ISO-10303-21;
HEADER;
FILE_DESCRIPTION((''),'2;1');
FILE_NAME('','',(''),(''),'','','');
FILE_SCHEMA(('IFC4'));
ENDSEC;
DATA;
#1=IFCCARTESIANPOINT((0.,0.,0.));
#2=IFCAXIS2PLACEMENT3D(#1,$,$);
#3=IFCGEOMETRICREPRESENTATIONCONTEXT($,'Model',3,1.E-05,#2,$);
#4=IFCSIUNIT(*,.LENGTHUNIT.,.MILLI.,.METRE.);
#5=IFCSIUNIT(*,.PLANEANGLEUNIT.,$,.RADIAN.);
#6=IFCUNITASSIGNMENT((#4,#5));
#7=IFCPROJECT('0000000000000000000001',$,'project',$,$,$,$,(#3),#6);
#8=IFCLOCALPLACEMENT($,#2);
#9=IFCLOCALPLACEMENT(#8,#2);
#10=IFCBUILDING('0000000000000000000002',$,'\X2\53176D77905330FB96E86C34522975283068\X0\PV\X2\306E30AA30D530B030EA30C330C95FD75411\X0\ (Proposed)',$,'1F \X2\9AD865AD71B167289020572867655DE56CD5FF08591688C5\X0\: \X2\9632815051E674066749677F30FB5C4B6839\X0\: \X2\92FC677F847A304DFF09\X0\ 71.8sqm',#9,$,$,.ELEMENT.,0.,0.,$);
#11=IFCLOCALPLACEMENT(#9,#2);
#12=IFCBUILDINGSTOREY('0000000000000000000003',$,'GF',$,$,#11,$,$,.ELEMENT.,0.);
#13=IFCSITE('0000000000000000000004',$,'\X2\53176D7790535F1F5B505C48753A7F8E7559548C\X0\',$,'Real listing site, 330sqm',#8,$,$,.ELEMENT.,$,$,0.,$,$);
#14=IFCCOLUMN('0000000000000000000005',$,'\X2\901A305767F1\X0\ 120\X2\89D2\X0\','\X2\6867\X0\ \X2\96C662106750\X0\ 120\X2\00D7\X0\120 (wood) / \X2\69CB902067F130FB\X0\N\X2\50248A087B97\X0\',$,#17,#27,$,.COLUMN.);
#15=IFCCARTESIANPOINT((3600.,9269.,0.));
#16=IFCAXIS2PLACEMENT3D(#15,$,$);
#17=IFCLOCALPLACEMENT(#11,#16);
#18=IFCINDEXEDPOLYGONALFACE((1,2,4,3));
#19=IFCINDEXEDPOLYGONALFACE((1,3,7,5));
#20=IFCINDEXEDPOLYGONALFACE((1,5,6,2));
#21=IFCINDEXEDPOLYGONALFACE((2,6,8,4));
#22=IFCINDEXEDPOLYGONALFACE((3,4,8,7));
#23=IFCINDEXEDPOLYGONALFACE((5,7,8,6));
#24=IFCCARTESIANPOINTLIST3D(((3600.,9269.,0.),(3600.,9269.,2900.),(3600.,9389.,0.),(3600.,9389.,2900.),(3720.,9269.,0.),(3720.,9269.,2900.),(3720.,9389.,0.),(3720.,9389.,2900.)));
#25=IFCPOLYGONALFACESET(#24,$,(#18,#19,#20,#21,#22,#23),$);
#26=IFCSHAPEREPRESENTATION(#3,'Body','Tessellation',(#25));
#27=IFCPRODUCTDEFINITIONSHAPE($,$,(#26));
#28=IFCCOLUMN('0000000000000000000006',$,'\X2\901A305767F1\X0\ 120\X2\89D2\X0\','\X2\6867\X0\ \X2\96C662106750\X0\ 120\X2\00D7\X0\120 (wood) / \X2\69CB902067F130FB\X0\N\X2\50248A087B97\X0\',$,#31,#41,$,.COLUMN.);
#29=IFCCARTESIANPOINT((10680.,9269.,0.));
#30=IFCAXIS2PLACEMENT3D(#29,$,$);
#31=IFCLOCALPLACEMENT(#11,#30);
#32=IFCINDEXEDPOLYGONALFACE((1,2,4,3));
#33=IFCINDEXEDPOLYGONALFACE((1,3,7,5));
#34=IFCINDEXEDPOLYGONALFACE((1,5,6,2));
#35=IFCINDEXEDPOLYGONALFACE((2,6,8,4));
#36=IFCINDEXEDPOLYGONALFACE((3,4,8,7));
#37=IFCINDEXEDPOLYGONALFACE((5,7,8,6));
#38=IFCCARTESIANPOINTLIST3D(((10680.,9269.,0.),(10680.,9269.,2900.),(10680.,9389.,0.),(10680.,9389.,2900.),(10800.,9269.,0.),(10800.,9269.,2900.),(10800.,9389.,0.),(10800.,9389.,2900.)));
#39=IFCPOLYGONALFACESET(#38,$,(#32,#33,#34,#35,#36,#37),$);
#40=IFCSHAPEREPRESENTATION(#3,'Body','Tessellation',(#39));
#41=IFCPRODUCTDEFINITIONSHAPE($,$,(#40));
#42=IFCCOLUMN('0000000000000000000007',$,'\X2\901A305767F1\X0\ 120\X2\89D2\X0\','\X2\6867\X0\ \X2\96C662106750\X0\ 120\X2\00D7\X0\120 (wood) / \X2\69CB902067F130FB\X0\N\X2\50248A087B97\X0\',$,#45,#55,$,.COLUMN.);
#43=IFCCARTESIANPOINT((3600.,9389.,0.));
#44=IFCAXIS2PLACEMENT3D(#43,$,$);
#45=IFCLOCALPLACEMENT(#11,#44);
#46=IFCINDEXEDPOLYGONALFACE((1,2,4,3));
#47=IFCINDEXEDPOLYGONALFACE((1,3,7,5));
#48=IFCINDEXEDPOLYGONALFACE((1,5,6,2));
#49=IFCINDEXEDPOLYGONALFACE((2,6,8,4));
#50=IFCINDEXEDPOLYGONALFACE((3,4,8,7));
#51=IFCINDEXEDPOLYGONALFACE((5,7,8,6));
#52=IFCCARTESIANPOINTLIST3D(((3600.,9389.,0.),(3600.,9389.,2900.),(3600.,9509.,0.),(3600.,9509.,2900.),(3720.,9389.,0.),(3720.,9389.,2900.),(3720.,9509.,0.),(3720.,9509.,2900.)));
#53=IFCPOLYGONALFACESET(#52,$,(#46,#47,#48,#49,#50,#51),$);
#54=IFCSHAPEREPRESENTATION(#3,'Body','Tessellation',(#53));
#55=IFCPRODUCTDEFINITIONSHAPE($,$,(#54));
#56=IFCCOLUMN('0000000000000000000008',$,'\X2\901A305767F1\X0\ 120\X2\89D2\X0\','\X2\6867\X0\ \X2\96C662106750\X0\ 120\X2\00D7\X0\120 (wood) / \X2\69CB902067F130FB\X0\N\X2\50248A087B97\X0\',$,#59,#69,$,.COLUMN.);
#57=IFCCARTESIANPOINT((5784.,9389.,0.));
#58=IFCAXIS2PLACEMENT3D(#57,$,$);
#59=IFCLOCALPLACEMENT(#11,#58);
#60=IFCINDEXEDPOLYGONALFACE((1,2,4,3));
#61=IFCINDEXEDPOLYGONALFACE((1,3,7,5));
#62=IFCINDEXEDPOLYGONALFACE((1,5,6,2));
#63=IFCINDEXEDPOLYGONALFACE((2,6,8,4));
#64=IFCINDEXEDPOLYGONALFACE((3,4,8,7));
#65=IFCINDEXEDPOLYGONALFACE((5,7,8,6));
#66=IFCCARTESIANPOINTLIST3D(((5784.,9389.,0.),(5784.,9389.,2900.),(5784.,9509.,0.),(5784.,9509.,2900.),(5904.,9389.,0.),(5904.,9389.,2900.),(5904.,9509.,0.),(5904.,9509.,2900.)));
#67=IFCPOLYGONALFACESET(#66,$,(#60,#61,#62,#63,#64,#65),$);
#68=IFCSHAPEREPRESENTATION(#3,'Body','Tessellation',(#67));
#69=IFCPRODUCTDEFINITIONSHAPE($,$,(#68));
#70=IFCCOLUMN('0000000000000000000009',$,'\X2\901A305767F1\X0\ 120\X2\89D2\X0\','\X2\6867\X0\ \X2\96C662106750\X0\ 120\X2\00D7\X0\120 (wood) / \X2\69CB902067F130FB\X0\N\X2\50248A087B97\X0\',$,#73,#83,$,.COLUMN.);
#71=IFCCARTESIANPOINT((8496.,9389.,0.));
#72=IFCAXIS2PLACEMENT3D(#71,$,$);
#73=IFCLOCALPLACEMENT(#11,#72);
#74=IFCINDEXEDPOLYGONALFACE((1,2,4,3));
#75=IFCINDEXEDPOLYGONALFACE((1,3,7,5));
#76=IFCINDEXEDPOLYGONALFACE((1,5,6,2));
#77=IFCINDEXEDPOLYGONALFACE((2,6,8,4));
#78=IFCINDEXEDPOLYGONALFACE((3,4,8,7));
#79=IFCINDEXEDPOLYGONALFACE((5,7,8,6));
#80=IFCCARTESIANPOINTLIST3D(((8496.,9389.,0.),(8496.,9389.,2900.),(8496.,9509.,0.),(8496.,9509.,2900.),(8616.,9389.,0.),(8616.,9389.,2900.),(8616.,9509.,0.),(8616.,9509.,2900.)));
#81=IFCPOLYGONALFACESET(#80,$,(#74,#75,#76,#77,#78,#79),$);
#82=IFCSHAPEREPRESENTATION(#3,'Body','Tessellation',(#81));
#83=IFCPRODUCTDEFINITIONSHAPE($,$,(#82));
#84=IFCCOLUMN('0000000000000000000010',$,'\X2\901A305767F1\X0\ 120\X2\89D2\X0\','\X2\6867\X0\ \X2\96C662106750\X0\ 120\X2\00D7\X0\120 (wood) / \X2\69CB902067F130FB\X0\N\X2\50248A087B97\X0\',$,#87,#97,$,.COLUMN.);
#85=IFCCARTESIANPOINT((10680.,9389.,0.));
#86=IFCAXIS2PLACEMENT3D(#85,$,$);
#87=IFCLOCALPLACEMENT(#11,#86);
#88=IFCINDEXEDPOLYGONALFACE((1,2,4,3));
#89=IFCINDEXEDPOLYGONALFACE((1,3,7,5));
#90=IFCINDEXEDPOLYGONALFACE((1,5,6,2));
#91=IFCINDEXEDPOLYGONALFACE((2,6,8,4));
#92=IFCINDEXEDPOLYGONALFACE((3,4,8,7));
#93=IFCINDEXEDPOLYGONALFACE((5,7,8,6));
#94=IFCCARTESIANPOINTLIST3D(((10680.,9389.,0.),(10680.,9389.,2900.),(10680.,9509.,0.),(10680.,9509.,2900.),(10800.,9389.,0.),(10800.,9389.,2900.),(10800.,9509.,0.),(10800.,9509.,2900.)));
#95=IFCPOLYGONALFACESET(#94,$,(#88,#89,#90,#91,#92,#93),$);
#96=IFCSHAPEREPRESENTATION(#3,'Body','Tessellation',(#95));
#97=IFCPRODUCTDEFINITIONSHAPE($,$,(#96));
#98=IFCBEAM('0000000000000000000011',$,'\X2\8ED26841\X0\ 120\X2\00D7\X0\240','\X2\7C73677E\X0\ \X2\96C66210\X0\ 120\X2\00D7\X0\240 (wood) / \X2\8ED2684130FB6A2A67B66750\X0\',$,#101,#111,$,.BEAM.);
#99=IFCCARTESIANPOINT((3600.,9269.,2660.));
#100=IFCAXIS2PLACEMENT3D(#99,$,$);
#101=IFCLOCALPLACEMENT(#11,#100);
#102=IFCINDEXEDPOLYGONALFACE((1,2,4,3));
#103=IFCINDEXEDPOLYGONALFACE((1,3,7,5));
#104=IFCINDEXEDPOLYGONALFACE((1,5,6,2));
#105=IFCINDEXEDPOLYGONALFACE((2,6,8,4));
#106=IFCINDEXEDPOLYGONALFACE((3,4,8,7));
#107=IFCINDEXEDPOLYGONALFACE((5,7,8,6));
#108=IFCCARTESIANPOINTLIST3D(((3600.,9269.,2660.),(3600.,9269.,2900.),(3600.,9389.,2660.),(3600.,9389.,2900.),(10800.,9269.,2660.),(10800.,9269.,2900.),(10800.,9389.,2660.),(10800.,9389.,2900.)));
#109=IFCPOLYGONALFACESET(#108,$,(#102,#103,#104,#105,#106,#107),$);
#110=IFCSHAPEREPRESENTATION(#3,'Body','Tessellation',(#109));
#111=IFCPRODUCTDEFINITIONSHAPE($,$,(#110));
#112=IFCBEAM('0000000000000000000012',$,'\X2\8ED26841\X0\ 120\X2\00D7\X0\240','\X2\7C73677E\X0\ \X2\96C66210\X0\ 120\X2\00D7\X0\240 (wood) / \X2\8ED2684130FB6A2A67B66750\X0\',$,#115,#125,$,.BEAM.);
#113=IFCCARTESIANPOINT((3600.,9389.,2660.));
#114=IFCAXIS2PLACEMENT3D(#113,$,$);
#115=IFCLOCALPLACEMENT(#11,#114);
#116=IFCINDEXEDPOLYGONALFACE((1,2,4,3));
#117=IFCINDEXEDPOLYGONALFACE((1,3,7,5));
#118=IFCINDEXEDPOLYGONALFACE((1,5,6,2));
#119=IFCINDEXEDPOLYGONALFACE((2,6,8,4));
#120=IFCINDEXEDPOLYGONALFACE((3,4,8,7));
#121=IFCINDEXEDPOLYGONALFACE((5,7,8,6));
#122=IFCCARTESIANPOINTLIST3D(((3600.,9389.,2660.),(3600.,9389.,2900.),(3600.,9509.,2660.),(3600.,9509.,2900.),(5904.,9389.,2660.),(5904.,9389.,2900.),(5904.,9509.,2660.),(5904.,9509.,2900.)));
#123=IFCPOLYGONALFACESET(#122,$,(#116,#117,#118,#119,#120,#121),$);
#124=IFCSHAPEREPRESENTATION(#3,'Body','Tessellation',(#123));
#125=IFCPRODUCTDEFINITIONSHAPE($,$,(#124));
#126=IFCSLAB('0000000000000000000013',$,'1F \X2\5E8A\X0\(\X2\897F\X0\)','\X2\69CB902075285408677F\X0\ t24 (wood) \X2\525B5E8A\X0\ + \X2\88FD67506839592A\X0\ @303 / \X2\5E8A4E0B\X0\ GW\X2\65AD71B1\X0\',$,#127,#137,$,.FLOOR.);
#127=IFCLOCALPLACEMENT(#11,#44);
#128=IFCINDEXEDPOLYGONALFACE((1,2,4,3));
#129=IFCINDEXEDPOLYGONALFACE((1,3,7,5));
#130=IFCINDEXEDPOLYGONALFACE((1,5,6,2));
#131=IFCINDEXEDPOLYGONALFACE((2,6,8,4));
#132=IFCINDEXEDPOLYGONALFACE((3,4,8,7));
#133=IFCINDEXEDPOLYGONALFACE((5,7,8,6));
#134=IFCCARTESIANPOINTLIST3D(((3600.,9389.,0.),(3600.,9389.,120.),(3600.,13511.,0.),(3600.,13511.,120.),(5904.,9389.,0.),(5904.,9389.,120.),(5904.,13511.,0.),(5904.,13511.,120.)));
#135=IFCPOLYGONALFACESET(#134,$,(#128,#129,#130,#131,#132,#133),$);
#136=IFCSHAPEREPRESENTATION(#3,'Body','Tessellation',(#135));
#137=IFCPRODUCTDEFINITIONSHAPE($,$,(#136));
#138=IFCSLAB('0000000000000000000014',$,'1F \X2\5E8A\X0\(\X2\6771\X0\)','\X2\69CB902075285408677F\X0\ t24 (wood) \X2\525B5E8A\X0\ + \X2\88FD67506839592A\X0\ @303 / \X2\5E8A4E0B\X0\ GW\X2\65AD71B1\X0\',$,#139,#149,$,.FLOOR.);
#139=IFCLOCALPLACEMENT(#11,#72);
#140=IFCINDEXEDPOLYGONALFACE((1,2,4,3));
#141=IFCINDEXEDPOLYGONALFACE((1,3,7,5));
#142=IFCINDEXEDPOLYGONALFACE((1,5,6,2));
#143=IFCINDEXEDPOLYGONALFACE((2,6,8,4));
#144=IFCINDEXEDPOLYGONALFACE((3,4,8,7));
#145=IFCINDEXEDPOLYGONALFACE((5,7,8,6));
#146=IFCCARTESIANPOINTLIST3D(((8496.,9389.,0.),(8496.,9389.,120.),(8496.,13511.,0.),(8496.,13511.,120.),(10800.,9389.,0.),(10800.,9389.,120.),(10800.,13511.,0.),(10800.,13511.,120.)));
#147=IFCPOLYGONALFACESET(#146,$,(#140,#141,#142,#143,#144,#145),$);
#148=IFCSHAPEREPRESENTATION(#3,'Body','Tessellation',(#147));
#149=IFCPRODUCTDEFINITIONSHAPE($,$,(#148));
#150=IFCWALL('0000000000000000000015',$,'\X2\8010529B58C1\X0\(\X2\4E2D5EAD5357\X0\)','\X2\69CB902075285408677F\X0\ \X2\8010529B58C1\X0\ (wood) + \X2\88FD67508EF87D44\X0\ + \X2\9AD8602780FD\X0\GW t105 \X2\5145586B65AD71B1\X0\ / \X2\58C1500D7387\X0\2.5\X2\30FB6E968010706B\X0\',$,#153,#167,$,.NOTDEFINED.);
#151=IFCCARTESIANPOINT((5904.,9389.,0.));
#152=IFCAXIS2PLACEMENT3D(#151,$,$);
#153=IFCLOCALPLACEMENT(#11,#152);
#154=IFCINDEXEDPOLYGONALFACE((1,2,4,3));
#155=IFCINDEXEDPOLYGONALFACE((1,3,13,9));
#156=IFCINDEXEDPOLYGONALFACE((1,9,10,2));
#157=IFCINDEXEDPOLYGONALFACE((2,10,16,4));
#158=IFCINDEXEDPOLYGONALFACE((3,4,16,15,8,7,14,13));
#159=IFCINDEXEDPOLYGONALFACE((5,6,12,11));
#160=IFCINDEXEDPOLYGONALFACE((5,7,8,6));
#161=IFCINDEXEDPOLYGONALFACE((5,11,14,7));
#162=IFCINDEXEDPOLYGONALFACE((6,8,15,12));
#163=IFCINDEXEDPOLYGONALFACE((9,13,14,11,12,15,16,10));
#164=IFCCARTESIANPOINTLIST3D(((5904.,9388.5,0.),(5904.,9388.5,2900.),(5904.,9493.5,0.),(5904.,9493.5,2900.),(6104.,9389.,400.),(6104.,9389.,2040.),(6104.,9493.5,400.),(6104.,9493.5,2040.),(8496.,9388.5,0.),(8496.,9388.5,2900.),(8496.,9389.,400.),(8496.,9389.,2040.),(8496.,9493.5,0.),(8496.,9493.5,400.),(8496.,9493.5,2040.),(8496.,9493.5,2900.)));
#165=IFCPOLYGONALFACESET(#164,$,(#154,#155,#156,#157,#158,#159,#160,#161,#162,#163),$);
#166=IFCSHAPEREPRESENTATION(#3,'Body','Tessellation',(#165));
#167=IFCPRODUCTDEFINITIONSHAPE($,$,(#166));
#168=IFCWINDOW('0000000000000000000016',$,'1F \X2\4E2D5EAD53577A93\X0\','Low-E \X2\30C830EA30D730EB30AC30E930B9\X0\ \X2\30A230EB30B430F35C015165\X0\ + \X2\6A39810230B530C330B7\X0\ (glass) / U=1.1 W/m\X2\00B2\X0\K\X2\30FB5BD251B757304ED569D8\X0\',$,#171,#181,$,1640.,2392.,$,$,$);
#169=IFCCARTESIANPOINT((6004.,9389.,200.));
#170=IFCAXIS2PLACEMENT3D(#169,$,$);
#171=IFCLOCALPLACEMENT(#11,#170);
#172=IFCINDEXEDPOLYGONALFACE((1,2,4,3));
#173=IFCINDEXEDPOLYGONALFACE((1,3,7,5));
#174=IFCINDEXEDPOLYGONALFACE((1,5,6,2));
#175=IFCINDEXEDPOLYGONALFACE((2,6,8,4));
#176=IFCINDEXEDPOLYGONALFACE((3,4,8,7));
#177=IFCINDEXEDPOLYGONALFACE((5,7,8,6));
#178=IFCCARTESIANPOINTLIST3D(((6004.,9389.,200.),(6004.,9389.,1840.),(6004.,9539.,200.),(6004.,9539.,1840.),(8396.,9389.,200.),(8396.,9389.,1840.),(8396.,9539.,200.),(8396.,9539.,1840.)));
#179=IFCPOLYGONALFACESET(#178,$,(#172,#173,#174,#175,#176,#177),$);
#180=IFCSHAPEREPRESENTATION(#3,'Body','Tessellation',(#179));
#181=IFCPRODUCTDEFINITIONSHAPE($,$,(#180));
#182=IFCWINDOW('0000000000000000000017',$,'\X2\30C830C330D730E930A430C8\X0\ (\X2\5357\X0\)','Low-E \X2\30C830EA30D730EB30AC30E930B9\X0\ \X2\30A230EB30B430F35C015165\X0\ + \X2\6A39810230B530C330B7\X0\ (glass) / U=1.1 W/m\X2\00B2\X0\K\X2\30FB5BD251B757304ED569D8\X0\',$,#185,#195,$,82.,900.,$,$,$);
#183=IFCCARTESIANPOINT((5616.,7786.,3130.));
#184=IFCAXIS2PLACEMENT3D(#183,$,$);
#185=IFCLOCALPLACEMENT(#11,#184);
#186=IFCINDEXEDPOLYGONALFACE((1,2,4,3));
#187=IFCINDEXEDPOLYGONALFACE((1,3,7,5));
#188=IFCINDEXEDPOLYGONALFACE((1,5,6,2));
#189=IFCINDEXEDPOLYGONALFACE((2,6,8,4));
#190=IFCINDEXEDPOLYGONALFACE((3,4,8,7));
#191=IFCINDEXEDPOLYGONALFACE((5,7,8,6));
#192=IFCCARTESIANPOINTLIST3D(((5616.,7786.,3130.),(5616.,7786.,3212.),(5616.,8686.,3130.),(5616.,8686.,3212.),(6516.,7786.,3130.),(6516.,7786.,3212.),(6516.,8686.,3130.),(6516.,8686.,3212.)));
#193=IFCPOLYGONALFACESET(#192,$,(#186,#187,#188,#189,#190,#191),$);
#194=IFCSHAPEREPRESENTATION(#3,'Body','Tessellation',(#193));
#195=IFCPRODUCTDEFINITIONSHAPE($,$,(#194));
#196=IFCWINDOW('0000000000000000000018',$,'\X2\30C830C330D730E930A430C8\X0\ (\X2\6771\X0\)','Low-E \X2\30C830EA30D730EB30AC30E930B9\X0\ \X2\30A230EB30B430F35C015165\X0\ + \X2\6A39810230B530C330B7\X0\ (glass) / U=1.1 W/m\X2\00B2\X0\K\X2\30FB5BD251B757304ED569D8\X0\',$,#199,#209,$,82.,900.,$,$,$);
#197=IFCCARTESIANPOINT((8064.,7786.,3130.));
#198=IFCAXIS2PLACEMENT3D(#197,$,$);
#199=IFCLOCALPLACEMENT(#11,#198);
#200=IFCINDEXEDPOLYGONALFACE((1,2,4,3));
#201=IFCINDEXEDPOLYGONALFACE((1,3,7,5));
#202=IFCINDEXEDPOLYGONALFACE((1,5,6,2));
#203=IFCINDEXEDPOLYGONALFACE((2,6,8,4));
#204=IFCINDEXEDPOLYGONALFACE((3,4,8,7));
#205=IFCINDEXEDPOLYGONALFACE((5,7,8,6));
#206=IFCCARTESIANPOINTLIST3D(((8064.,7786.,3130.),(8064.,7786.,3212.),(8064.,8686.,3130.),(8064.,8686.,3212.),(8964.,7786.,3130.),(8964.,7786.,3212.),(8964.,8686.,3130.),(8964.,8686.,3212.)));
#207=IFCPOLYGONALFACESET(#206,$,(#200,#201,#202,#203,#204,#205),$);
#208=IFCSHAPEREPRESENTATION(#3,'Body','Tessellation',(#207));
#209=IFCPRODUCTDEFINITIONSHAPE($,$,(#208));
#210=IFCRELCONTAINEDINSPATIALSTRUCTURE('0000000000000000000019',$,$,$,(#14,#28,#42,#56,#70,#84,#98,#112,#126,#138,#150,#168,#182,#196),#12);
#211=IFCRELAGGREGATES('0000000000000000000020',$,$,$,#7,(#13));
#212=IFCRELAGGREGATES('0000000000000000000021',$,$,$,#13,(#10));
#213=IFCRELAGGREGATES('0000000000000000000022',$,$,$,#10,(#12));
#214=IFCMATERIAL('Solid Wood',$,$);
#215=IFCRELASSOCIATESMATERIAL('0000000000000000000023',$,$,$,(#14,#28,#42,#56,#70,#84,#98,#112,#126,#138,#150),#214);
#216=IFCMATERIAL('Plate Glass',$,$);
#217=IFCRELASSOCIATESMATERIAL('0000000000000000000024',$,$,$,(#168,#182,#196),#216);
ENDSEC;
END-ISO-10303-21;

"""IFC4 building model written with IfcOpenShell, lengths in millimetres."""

from ifc_helpers import new_model, si_unit, frame, frame_2d, origin, place, context, project, spatial, rectangle, extrude, material, element, fill, save


model = new_model("IFC4")

# Units and contexts
model_context = context("Model", 3, precision=1e-05, world=origin())
ifc_project = project(units=[si_unit("LENGTHUNIT", "METRE", prefix="MILLI"), si_unit("PLANEANGLEUNIT", "RADIAN")], contexts=[model_context])

# Site, building, storey
site_placement = place(None, origin())
site = spatial("IfcSite", under=ifc_project, at=site_placement, Name="北海道弟子屈町美留和", ObjectType="Real listing site, 330sqm", CompositionType="ELEMENT", RefElevation=0.0)
building_placement = place(site_placement, origin())
building = spatial("IfcBuilding", under=site, at=building_placement, Name="北海道・雨水利用とPVのオフグリッド志向 (Proposed)", ObjectType="1F 高断熱木造在来工法（外装: 防腐処理杉板・屋根: 鋼板葺き） 71.8sqm", CompositionType="ELEMENT", ElevationOfRefHeight=0.0, ElevationOfTerrain=0.0)
storey_placement = place(building_placement, origin())
storey = spatial("IfcBuildingStorey", under=building, at=storey_placement, Name="GF", CompositionType="ELEMENT", Elevation=0.0)

# Columns
ifc_material_1 = material(Name="Solid Wood")
column_1_placement = place(storey_placement, frame((3600.0, 9269.0, 0.0)))
element("IfcColumn", 1, at=column_1_placement, inside=storey, material=ifc_material_1, Name="通し柱 120角", Description="桧 集成材 120×120 (wood) / 構造柱・N値計算", PredefinedType="COLUMN", context=model_context, shape_type="SweptSolid", body=[
    extrude(rectangle(XDim=120.0, YDim=120.0, at=frame_2d((60.0, 60.0))), frame((3600.0, 9269.0, 0.0)), (0.0, 0.0, 1.0), 2900.0),
])
column_2_placement = place(storey_placement, frame((10680.0, 9269.0, 0.0)))
element("IfcColumn", 2, at=column_2_placement, inside=storey, material=ifc_material_1, Name="通し柱 120角", Description="桧 集成材 120×120 (wood) / 構造柱・N値計算", PredefinedType="COLUMN", context=model_context, shape_type="SweptSolid", body=[
    extrude(rectangle(XDim=120.0, YDim=120.0, at=frame_2d((60.0, 60.0))), frame((10680.0, 9269.0, 0.0)), (0.0, 0.0, 1.0), 2900.0),
])
column_3_placement = place(storey_placement, frame((3600.0, 9389.0, 0.0)))
element("IfcColumn", 3, at=column_3_placement, inside=storey, material=ifc_material_1, Name="通し柱 120角", Description="桧 集成材 120×120 (wood) / 構造柱・N値計算", PredefinedType="COLUMN", context=model_context, shape_type="SweptSolid", body=[
    extrude(rectangle(XDim=120.0, YDim=120.0, at=frame_2d((60.0, 60.0))), frame((3600.0, 9389.0, 0.0)), (0.0, 0.0, 1.0), 2900.0),
])
column_4_placement = place(storey_placement, frame((5784.0, 9389.0, 0.0)))
element("IfcColumn", 4, at=column_4_placement, inside=storey, material=ifc_material_1, Name="通し柱 120角", Description="桧 集成材 120×120 (wood) / 構造柱・N値計算", PredefinedType="COLUMN", context=model_context, shape_type="SweptSolid", body=[
    extrude(rectangle(XDim=120.0, YDim=120.0, at=frame_2d((60.0, 60.0))), frame((5784.0, 9389.0, 0.0)), (0.0, 0.0, 1.0), 2900.0),
])
column_5_placement = place(storey_placement, frame((8496.0, 9389.0, 0.0)))
element("IfcColumn", 5, at=column_5_placement, inside=storey, material=ifc_material_1, Name="通し柱 120角", Description="桧 集成材 120×120 (wood) / 構造柱・N値計算", PredefinedType="COLUMN", context=model_context, shape_type="SweptSolid", body=[
    extrude(rectangle(XDim=120.0, YDim=120.0, at=frame_2d((60.0, 60.0))), frame((8496.0, 9389.0, 0.0)), (0.0, 0.0, 1.0), 2900.0),
])
column_6_placement = place(storey_placement, frame((10680.0, 9389.0, 0.0)))
element("IfcColumn", 6, at=column_6_placement, inside=storey, material=ifc_material_1, Name="通し柱 120角", Description="桧 集成材 120×120 (wood) / 構造柱・N値計算", PredefinedType="COLUMN", context=model_context, shape_type="SweptSolid", body=[
    extrude(rectangle(XDim=120.0, YDim=120.0, at=frame_2d((60.0, 60.0))), frame((10680.0, 9389.0, 0.0)), (0.0, 0.0, 1.0), 2900.0),
])

# Beams
beam_1_placement = place(storey_placement, frame((3600.0, 9269.0, 2660.0)))
element("IfcBeam", 7, at=beam_1_placement, inside=storey, material=ifc_material_1, Name="軒桁 120×240", Description="米松 集成 120×240 (wood) / 軒桁・横架材", PredefinedType="BEAM", context=model_context, shape_type="SweptSolid", body=[
    extrude(rectangle(XDim=7200.0, YDim=120.0, at=frame_2d((3600.0, 60.0))), frame((3600.0, 9269.0, 2660.0)), (0.0, 0.0, 1.0), 240.0),
])
beam_2_placement = place(storey_placement, frame((3600.0, 9389.0, 2660.0)))
element("IfcBeam", 8, at=beam_2_placement, inside=storey, material=ifc_material_1, Name="軒桁 120×240", Description="米松 集成 120×240 (wood) / 軒桁・横架材", PredefinedType="BEAM", context=model_context, shape_type="SweptSolid", body=[
    extrude(rectangle(XDim=2304.0, YDim=120.0, at=frame_2d((1152.0, 60.0))), frame((3600.0, 9389.0, 2660.0)), (0.0, 0.0, 1.0), 240.0),
])

# Slabs
slab_1_placement = place(storey_placement, frame((3600.0, 9389.0, 0.0)))
element("IfcSlab", 9, at=slab_1_placement, inside=storey, material=ifc_material_1, Name="1F 床(西)", Description="構造用合板 t24 (wood) 剛床 + 製材根太 @303 / 床下 GW断熱", PredefinedType="FLOOR", context=model_context, shape_type="SweptSolid", body=[
    extrude(rectangle(XDim=2304.0, YDim=4122.0, at=frame_2d((1152.0, 2061.0))), frame((3600.0, 9389.0, 0.0)), (0.0, 0.0, 1.0), 120.0),
])
slab_2_placement = place(storey_placement, frame((8496.0, 9389.0, 0.0)))
element("IfcSlab", 10, at=slab_2_placement, inside=storey, material=ifc_material_1, Name="1F 床(東)", Description="構造用合板 t24 (wood) 剛床 + 製材根太 @303 / 床下 GW断熱", PredefinedType="FLOOR", context=model_context, shape_type="SweptSolid", body=[
    extrude(rectangle(XDim=2304.0, YDim=4122.0, at=frame_2d((1152.0, 2061.0))), frame((8496.0, 9389.0, 0.0)), (0.0, 0.0, 1.0), 120.0),
])

# Wall, opening, window
wall_1_placement = place(storey_placement, frame((5904.0, 9389.0, 0.0)))
wall_1 = element("IfcWall", 11, at=wall_1_placement, inside=storey, material=ifc_material_1, Name="耐力壁(中庭南)", Description="構造用合板 耐力壁 (wood) + 製材軸組 + 高性能GW t105 充填断熱 / 壁倍率2.5・準耐火", PredefinedType="NOTDEFINED", context=model_context, shape_type="SweptSolid", body=[
    extrude(rectangle(XDim=2592.0, YDim=105.0, at=frame_2d((1296.0, 52.0))), frame((5904.0, 9389.0, 0.0)), (0.0, 0.0, 1.0), 2900.0),
])
opening_placement = place(storey_placement, frame((6004.0, 9389.0, 200.0)))
opening = element("IfcOpeningElement", 12, at=opening_placement, cuts=wall_1, PredefinedType="NOTDEFINED", context=model_context, shape_type="SweptSolid", body=[
    extrude(rectangle(XDim=2392.0, YDim=150.0, at=frame_2d((1196.0, 75.0))), frame((6004.0, 9389.0, 200.0)), (0.0, 0.0, 1.0), 1640.0),
])
ifc_material_2 = material(Name="Plate Glass")
window_1_placement = place(storey_placement, frame((6004.0, 9389.0, 200.0)))
window_1 = element("IfcWindow", 13, at=window_1_placement, inside=storey, material=ifc_material_2, Name="1F 中庭南窓", Description="Low-E トリプルガラス アルゴン封入 + 樹脂サッシ (glass) / U=1.1 W/m²K・寒冷地仕様", OverallHeight=1640.0, OverallWidth=2392.0, context=model_context, shape_type="SweptSolid", body=[
    extrude(rectangle(XDim=2392.0, YDim=150.0, at=frame_2d((1196.0, 75.0))), frame((6004.0, 9389.0, 200.0)), (0.0, 0.0, 1.0), 1640.0),
])
fill(opening, window_1)

# Windows
window_2_placement = place(storey_placement, frame((5616.0, 7786.0, 3130.0)))
element("IfcWindow", 14, at=window_2_placement, inside=storey, material=ifc_material_2, Name="トップライト (南)", Description="Low-E トリプルガラス アルゴン封入 + 樹脂サッシ (glass) / U=1.1 W/m²K・寒冷地仕様", OverallHeight=82.0, OverallWidth=900.0, context=model_context, shape_type="SweptSolid", body=[
    extrude(rectangle(XDim=900.0, YDim=900.0, at=frame_2d((450.0, 450.0))), frame((5616.0, 7786.0, 3130.0)), (0.0, 0.0, 1.0), 82.0),
])
window_3_placement = place(storey_placement, frame((8064.0, 7786.0, 3130.0)))
element("IfcWindow", 15, at=window_3_placement, inside=storey, material=ifc_material_2, Name="トップライト (東)", Description="Low-E トリプルガラス アルゴン封入 + 樹脂サッシ (glass) / U=1.1 W/m²K・寒冷地仕様", OverallHeight=82.0, OverallWidth=900.0, context=model_context, shape_type="SweptSolid", body=[
    extrude(rectangle(XDim=900.0, YDim=900.0, at=frame_2d((450.0, 450.0))), frame((8064.0, 7786.0, 3130.0)), (0.0, 0.0, 1.0), 82.0),
])

save(model, "model.ifc")
